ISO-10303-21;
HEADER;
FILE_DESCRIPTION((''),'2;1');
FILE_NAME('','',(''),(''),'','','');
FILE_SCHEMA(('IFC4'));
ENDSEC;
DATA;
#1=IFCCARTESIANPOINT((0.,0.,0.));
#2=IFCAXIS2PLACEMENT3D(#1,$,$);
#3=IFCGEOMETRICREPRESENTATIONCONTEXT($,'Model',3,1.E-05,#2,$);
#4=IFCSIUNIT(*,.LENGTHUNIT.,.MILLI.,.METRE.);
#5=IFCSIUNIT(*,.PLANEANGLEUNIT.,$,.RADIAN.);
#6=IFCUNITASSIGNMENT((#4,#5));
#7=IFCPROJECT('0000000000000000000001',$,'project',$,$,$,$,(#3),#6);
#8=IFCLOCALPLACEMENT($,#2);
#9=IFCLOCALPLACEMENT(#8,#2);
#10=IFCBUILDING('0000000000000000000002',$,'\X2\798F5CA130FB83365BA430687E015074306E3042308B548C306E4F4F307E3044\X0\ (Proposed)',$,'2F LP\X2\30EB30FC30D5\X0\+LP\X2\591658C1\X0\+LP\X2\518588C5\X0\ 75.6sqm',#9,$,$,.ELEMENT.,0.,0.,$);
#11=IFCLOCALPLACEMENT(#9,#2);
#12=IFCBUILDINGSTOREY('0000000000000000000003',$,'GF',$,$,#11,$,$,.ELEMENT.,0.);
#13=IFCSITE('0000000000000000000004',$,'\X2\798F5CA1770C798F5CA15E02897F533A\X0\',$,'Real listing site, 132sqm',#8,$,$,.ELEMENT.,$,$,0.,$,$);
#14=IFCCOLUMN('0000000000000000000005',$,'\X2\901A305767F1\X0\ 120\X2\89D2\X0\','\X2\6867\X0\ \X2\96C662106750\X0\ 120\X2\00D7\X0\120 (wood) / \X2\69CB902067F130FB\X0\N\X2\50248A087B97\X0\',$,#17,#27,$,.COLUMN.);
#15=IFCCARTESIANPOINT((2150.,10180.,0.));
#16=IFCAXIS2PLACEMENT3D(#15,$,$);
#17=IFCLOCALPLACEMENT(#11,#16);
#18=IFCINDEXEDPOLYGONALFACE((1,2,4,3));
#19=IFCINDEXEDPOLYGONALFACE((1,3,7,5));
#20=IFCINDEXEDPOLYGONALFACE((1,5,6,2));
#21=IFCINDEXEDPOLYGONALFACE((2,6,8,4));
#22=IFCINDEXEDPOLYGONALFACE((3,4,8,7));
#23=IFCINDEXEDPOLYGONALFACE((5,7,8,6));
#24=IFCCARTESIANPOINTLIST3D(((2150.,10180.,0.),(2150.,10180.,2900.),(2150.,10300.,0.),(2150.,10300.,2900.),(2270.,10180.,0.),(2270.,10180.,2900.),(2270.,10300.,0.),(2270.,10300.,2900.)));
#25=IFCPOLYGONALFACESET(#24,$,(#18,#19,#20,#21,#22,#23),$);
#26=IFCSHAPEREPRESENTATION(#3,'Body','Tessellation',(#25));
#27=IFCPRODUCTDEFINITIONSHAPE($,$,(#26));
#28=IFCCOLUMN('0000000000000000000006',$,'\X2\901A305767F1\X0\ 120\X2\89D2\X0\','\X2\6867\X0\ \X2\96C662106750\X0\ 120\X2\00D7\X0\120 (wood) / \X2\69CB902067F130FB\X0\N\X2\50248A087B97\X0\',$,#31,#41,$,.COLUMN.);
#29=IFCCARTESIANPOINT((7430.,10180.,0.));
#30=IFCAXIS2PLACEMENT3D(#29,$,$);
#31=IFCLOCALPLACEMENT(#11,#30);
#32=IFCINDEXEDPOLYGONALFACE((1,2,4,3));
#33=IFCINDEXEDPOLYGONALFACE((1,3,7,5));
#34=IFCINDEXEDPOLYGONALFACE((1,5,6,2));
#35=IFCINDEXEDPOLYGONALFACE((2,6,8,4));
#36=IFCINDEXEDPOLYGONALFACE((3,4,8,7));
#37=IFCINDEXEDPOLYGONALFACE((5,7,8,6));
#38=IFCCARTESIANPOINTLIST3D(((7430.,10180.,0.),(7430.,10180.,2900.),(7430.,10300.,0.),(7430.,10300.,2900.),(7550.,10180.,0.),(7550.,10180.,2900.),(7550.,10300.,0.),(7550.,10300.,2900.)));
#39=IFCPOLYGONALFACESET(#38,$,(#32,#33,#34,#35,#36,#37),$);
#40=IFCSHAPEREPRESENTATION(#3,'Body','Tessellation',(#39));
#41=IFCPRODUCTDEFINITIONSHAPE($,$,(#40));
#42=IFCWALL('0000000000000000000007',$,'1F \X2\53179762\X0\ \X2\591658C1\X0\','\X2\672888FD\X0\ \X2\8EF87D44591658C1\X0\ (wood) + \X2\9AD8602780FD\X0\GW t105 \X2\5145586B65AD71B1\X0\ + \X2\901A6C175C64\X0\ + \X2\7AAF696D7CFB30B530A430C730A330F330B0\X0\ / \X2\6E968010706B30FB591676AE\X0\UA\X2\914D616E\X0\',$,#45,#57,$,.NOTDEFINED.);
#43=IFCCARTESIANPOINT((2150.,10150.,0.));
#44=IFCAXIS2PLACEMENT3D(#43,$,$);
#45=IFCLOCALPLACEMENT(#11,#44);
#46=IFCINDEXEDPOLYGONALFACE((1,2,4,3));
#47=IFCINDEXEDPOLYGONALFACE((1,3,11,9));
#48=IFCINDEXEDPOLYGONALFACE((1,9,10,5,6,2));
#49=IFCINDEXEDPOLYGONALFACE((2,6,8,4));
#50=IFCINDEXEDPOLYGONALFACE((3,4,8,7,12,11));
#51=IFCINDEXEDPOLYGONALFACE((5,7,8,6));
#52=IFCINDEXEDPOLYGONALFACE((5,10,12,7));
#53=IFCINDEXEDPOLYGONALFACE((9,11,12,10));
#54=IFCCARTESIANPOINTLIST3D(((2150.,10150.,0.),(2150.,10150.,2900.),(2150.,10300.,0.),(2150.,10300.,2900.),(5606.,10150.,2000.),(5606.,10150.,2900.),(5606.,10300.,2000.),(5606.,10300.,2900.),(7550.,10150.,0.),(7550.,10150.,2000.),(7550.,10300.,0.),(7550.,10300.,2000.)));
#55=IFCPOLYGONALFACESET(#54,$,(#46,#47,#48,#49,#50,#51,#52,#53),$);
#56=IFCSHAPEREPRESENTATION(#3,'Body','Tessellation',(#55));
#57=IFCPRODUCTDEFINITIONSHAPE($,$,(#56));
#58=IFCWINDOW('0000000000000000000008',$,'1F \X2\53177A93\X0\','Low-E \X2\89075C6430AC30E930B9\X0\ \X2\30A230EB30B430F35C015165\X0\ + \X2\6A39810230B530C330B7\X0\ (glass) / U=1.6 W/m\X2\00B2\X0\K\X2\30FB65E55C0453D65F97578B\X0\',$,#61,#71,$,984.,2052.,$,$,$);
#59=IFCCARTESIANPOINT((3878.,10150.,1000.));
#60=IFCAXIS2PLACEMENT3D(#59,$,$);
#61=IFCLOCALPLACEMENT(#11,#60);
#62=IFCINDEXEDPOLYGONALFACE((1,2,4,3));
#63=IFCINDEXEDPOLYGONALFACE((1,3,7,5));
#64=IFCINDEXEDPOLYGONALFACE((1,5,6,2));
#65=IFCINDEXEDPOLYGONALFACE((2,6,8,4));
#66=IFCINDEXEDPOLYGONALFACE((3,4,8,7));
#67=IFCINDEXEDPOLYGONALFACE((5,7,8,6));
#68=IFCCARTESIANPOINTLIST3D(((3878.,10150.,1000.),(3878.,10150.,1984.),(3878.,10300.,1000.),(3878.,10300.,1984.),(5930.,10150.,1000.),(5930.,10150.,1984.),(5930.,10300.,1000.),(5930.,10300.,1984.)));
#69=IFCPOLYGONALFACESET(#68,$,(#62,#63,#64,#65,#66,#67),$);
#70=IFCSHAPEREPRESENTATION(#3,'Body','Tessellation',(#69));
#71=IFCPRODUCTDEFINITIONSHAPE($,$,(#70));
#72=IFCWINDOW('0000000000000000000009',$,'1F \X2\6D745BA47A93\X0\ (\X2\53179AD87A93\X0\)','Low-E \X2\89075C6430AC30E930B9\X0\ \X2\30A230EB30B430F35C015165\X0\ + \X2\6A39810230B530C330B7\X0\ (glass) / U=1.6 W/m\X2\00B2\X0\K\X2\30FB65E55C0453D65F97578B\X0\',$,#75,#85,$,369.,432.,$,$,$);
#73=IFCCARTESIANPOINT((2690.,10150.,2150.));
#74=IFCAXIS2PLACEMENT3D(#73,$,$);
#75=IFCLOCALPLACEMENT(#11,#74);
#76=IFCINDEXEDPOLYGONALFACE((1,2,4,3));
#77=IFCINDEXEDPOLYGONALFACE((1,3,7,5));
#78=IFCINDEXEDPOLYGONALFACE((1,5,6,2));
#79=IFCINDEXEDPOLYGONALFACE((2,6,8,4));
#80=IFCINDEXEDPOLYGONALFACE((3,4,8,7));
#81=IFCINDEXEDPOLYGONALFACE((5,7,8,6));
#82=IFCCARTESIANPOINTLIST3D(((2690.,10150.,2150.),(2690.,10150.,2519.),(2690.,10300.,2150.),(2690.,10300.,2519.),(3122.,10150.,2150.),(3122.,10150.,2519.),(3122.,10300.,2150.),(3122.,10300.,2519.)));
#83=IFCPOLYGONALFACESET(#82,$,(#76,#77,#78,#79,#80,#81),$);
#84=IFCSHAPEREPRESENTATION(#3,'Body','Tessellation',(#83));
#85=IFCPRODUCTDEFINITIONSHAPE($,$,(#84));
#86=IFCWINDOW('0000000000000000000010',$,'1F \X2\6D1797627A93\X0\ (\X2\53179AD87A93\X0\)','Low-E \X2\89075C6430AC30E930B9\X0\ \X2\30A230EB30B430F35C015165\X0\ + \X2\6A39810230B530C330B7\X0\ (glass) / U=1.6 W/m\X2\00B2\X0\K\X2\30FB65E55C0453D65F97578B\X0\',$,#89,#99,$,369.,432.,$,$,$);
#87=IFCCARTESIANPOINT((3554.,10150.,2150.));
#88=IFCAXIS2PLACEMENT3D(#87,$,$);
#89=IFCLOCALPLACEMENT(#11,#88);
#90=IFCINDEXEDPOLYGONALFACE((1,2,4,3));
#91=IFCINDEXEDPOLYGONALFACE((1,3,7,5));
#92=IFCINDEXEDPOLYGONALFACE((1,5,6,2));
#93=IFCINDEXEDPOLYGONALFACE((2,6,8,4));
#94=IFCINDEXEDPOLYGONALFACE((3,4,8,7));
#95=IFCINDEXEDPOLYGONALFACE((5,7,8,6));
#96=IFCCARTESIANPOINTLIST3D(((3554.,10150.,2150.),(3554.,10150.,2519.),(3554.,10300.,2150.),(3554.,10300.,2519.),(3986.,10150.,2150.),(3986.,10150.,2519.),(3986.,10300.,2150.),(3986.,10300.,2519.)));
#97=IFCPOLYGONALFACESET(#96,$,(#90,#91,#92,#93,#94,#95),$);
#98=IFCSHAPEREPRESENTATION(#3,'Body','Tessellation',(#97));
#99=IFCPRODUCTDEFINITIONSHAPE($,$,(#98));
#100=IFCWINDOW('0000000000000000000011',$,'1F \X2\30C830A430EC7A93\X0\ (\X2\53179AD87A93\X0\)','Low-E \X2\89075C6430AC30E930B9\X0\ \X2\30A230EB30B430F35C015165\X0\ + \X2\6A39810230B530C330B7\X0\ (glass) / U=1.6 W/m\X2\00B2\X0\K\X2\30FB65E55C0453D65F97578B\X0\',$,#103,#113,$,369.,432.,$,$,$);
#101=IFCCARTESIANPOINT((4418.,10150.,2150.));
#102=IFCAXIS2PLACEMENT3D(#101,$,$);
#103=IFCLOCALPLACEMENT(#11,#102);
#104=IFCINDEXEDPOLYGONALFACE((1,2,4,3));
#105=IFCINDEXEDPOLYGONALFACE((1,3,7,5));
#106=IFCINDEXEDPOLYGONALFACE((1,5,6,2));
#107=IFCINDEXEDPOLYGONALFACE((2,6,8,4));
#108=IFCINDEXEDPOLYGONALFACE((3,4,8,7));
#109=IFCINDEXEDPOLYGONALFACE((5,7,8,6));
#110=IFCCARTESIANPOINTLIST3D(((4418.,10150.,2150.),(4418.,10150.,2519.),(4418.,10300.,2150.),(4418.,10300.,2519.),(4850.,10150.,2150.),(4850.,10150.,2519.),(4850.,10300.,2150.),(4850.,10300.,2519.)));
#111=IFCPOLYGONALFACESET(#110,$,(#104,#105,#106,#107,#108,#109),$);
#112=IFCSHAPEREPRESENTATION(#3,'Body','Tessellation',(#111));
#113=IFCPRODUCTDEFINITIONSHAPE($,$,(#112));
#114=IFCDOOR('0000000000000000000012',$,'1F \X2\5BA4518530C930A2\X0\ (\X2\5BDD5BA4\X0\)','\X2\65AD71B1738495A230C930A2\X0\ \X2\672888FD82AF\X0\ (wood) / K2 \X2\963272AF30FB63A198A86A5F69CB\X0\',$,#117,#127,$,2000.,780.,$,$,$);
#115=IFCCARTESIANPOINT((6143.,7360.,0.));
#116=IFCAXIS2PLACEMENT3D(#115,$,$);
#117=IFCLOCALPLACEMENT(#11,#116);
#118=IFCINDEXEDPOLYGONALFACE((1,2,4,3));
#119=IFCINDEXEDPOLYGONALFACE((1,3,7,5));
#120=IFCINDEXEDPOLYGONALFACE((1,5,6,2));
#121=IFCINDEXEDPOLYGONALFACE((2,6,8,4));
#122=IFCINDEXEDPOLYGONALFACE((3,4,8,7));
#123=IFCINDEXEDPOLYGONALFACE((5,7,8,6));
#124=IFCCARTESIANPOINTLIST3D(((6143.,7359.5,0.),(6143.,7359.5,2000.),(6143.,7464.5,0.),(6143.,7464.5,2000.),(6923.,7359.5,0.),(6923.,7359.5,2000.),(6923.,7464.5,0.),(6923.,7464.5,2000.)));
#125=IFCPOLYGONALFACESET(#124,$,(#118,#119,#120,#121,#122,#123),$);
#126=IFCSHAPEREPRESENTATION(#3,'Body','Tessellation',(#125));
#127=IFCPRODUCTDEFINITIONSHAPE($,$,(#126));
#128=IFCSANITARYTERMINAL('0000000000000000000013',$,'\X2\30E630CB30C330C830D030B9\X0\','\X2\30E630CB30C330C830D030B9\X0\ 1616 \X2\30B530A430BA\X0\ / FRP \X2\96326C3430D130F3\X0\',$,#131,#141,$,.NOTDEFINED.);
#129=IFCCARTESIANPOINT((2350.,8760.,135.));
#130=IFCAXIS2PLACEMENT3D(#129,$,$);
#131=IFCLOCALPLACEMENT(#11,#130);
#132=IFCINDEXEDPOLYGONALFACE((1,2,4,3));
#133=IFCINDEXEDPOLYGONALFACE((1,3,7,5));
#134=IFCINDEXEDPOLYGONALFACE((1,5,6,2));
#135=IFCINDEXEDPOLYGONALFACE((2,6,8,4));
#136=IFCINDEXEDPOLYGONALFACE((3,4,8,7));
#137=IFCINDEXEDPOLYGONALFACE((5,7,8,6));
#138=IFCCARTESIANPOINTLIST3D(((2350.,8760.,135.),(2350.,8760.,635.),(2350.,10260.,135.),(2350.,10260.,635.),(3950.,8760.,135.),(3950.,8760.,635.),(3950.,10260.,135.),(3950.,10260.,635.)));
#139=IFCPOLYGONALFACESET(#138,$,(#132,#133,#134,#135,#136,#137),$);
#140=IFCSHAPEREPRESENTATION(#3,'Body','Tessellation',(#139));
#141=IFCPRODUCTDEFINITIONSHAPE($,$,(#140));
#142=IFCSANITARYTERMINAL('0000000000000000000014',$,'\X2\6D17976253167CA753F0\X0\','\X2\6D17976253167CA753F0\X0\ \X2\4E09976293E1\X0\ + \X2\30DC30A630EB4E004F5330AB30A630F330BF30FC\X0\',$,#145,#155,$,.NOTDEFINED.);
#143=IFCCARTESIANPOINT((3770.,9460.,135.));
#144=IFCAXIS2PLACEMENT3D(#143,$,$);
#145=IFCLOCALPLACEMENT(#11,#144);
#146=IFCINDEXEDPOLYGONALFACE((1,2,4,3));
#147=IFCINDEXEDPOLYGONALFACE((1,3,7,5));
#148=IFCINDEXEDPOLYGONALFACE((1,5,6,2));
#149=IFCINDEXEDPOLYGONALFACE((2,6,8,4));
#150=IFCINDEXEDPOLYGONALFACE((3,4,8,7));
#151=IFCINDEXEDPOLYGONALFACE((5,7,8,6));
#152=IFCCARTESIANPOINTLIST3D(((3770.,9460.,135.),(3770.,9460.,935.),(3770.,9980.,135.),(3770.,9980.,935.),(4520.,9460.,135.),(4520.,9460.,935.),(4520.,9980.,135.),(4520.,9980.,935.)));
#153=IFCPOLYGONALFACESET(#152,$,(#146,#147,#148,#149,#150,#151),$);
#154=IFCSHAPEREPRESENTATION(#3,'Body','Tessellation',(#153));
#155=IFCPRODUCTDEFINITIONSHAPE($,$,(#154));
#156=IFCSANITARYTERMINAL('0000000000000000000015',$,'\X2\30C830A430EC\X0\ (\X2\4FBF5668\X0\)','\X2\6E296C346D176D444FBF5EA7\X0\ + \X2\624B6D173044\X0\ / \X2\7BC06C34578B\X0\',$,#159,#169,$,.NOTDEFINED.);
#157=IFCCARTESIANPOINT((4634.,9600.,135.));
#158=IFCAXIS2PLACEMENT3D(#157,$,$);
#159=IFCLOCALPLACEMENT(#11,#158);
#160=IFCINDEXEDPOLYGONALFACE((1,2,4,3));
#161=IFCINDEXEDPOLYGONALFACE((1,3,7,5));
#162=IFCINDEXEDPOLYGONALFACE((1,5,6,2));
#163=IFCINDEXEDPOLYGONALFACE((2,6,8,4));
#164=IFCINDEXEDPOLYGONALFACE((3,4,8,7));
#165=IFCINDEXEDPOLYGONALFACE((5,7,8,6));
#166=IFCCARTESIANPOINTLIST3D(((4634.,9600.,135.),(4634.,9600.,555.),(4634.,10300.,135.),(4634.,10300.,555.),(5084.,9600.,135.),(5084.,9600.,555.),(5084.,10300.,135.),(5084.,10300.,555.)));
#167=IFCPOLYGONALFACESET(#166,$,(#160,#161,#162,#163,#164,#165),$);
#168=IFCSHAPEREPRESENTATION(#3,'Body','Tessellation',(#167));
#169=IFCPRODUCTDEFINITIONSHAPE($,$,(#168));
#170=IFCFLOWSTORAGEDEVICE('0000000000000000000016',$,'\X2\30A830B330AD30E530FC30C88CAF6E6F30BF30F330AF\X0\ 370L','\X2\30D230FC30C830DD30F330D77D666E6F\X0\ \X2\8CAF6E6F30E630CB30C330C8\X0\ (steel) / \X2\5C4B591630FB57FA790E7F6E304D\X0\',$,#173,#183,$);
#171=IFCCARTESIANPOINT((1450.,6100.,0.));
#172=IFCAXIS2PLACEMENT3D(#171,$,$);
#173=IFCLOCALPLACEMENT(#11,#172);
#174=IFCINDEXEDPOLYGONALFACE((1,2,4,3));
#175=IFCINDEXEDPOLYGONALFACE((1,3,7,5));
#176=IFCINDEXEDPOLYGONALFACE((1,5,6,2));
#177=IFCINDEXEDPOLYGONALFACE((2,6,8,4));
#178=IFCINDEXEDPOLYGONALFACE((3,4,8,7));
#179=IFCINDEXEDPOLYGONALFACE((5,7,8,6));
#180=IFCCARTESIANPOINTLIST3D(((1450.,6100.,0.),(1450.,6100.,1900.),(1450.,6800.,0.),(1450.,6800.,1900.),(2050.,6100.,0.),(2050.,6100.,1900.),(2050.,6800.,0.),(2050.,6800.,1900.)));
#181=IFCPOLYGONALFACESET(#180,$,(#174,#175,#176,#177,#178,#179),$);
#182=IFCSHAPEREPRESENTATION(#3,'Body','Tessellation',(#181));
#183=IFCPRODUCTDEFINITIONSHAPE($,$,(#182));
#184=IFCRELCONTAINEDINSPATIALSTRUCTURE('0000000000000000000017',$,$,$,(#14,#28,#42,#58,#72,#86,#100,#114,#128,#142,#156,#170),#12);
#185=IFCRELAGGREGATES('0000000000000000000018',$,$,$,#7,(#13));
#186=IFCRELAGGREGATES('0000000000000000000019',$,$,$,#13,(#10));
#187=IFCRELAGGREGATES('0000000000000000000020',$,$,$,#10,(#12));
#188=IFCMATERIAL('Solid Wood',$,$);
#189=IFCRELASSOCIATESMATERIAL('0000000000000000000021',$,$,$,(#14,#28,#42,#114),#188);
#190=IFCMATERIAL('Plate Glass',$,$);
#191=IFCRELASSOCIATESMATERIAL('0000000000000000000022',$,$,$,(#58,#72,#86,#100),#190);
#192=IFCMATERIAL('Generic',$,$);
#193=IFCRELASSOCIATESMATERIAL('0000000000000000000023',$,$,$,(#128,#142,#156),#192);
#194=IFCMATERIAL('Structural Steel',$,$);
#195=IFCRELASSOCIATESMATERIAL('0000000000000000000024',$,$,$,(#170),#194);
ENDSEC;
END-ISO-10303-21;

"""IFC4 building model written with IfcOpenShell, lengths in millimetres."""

from ifc_helpers import new_model, si_unit, frame, frame_2d, origin, place, context, project, spatial, rectangle, extrude, material, element, fill, save


model = new_model("IFC4")

# Units and contexts
model_context = context("Model", 3, precision=1e-05, world=origin())
ifc_project = project(units=[si_unit("LENGTHUNIT", "METRE", prefix="MILLI"), si_unit("PLANEANGLEUNIT", "RADIAN")], contexts=[model_context])

# Site, building, storey
site_placement = place(None, origin())
site = spatial("IfcSite", under=ifc_project, at=site_placement, Name="福岡県福岡市西区", ObjectType="Real listing site, 132sqm", CompositionType="ELEMENT", RefElevation=0.0)
building_placement = place(site_placement, origin())
building = spatial("IfcBuilding", under=site, at=building_placement, Name="福岡・茶室と縁側のある和の住まい (Proposed)", ObjectType="2F LPルーフ+LP外壁+LP内装 75.6sqm", CompositionType="ELEMENT", ElevationOfRefHeight=0.0, ElevationOfTerrain=0.0)
storey_placement = place(building_placement, origin())
storey = spatial("IfcBuildingStorey", under=building, at=storey_placement, Name="GF", CompositionType="ELEMENT", Elevation=0.0)

# Columns
ifc_material_1 = material(Name="Solid Wood")
column_1_placement = place(storey_placement, frame((2150.0, 10180.0, 0.0)))
element("IfcColumn", 1, at=column_1_placement, inside=storey, material=ifc_material_1, Name="通し柱 120角", Description="桧 集成材 120×120 (wood) / 構造柱・N値計算", PredefinedType="COLUMN", context=model_context, shape_type="SweptSolid", body=[
    extrude(rectangle(XDim=120.0, YDim=120.0, at=frame_2d((60.0, 60.0))), frame((2150.0, 10180.0, 0.0)), (0.0, 0.0, 1.0), 2900.0),
])
column_2_placement = place(storey_placement, frame((7430.0, 10180.0, 0.0)))
element("IfcColumn", 2, at=column_2_placement, inside=storey, material=ifc_material_1, Name="通し柱 120角", Description="桧 集成材 120×120 (wood) / 構造柱・N値計算", PredefinedType="COLUMN", context=model_context, shape_type="SweptSolid", body=[
    extrude(rectangle(XDim=120.0, YDim=120.0, at=frame_2d((60.0, 60.0))), frame((7430.0, 10180.0, 0.0)), (0.0, 0.0, 1.0), 2900.0),
])

# Wall, openings, windows
wall_1_placement = place(storey_placement, frame((2150.0, 10150.0, 0.0)))
wall_1 = element("IfcWall", 3, at=wall_1_placement, inside=storey, material=ifc_material_1, Name="1F 北面 外壁", Description="木製 軸組外壁 (wood) + 高性能GW t105 充填断熱 + 通気層 + 窯業系サイディング / 準耐火・外皮UA配慮", PredefinedType="NOTDEFINED", context=model_context, shape_type="SweptSolid", body=[
    extrude(rectangle(XDim=5400.0, YDim=150.0, at=frame_2d((2700.0, 75.0))), frame((2150.0, 10150.0, 0.0)), (0.0, 0.0, 1.0), 2900.0),
])
opening_1_placement = place(storey_placement, frame((3878.0, 10150.0, 1000.0)))
opening_1 = element("IfcOpeningElement", 4, at=opening_1_placement, cuts=wall_1, PredefinedType="NOTDEFINED", context=model_context, shape_type="SweptSolid", body=[
    extrude(rectangle(XDim=2052.0, YDim=150.0, at=frame_2d((1026.0, 75.0))), frame((3878.0, 10150.0, 1000.0)), (0.0, 0.0, 1.0), 984.0),
])
opening_2_placement = place(storey_placement, frame((2690.0, 10150.0, 2150.0)))
opening_2 = element("IfcOpeningElement", 5, at=opening_2_placement, cuts=wall_1, PredefinedType="NOTDEFINED", context=model_context, shape_type="SweptSolid", body=[
    extrude(rectangle(XDim=432.0, YDim=150.0, at=frame_2d((216.0, 75.0))), frame((2690.0, 10150.0, 2150.0)), (0.0, 0.0, 1.0), 369.0),
])
opening_3_placement = place(storey_placement, frame((3554.0, 10150.0, 2150.0)))
opening_3 = element("IfcOpeningElement", 6, at=opening_3_placement, cuts=wall_1, PredefinedType="NOTDEFINED", context=model_context, shape_type="SweptSolid", body=[
    extrude(rectangle(XDim=432.0, YDim=150.0, at=frame_2d((216.0, 75.0))), frame((3554.0, 10150.0, 2150.0)), (0.0, 0.0, 1.0), 369.0),
])
opening_4_placement = place(storey_placement, frame((4418.0, 10150.0, 2150.0)))
opening_4 = element("IfcOpeningElement", 7, at=opening_4_placement, cuts=wall_1, PredefinedType="NOTDEFINED", context=model_context, shape_type="SweptSolid", body=[
    extrude(rectangle(XDim=432.0, YDim=150.0, at=frame_2d((216.0, 75.0))), frame((4418.0, 10150.0, 2150.0)), (0.0, 0.0, 1.0), 369.0),
])
ifc_material_2 = material(Name="Plate Glass")
window_1_placement = place(storey_placement, frame((3878.0, 10150.0, 1000.0)))
window_1 = element("IfcWindow", 8, at=window_1_placement, inside=storey, material=ifc_material_2, Name="1F 北窓", Description="Low-E 複層ガラス アルゴン封入 + 樹脂サッシ (glass) / U=1.6 W/m²K・日射取得型", OverallHeight=984.0, OverallWidth=2052.0, context=model_context, shape_type="SweptSolid", body=[
    extrude(rectangle(XDim=2052.0, YDim=150.0, at=frame_2d((1026.0, 75.0))), frame((3878.0, 10150.0, 1000.0)), (0.0, 0.0, 1.0), 984.0),
])
fill(opening_1, window_1)
window_2_placement = place(storey_placement, frame((2690.0, 10150.0, 2150.0)))
window_2 = element("IfcWindow", 9, at=window_2_placement, inside=storey, material=ifc_material_2, Name="1F 浴室窓 (北高窓)", Description="Low-E 複層ガラス アルゴン封入 + 樹脂サッシ (glass) / U=1.6 W/m²K・日射取得型", OverallHeight=369.0, OverallWidth=432.0, context=model_context, shape_type="SweptSolid", body=[
    extrude(rectangle(XDim=432.0, YDim=150.0, at=frame_2d((216.0, 75.0))), frame((2690.0, 10150.0, 2150.0)), (0.0, 0.0, 1.0), 369.0),
])
fill(opening_2, window_2)
window_3_placement = place(storey_placement, frame((3554.0, 10150.0, 2150.0)))
window_3 = element("IfcWindow", 10, at=window_3_placement, inside=storey, material=ifc_material_2, Name="1F 洗面窓 (北高窓)", Description="Low-E 複層ガラス アルゴン封入 + 樹脂サッシ (glass) / U=1.6 W/m²K・日射取得型", OverallHeight=369.0, OverallWidth=432.0, context=model_context, shape_type="SweptSolid", body=[
    extrude(rectangle(XDim=432.0, YDim=150.0, at=frame_2d((216.0, 75.0))), frame((3554.0, 10150.0, 2150.0)), (0.0, 0.0, 1.0), 369.0),
])
fill(opening_3, window_3)
window_4_placement = place(storey_placement, frame((4418.0, 10150.0, 2150.0)))
window_4 = element("IfcWindow", 11, at=window_4_placement, inside=storey, material=ifc_material_2, Name="1F トイレ窓 (北高窓)", Description="Low-E 複層ガラス アルゴン封入 + 樹脂サッシ (glass) / U=1.6 W/m²K・日射取得型", OverallHeight=369.0, OverallWidth=432.0, context=model_context, shape_type="SweptSolid", body=[
    extrude(rectangle(XDim=432.0, YDim=150.0, at=frame_2d((216.0, 75.0))), frame((4418.0, 10150.0, 2150.0)), (0.0, 0.0, 1.0), 369.0),
])
fill(opening_4, window_4)

# Door
door_1_placement = place(storey_placement, frame((6143.0, 7360.0, 0.0)))
element("IfcDoor", 12, at=door_1_placement, inside=storey, material=ifc_material_1, Name="1F 室内ドア (寝室)", Description="断熱玄関ドア 木製芯 (wood) / K2 防犯・採風機構", OverallHeight=2000.0, OverallWidth=780.0, context=model_context, shape_type="SweptSolid", body=[
    extrude(rectangle(XDim=780.0, YDim=105.0, at=frame_2d((390.0, 52.0))), frame((6143.0, 7360.0, 0.0)), (0.0, 0.0, 1.0), 2000.0),
])

# Sanitary terminals
ifc_material_3 = material(Name="Generic")
sanitary_terminal_1_placement = place(storey_placement, frame((2350.0, 8760.0, 135.0)))
element("IfcSanitaryTerminal", 13, at=sanitary_terminal_1_placement, inside=storey, material=ifc_material_3, Name="ユニットバス", Description="ユニットバス 1616 サイズ / FRP 防水パン", PredefinedType="NOTDEFINED", context=model_context, shape_type="SweptSolid", body=[
    extrude(rectangle(XDim=1600.0, YDim=1500.0, at=frame_2d((800.0, 750.0))), frame((2350.0, 8760.0, 135.0)), (0.0, 0.0, 1.0), 500.0),
])
sanitary_terminal_2_placement = place(storey_placement, frame((3770.0, 9460.0, 135.0)))
element("IfcSanitaryTerminal", 14, at=sanitary_terminal_2_placement, inside=storey, material=ifc_material_3, Name="洗面化粧台", Description="洗面化粧台 三面鏡 + ボウル一体カウンター", PredefinedType="NOTDEFINED", context=model_context, shape_type="SweptSolid", body=[
    extrude(rectangle(XDim=750.0, YDim=520.0, at=frame_2d((375.0, 260.0))), frame((3770.0, 9460.0, 135.0)), (0.0, 0.0, 1.0), 800.0),
])
sanitary_terminal_3_placement = place(storey_placement, frame((4634.0, 9600.0, 135.0)))
element("IfcSanitaryTerminal", 15, at=sanitary_terminal_3_placement, inside=storey, material=ifc_material_3, Name="トイレ (便器)", Description="温水洗浄便座 + 手洗い / 節水型", PredefinedType="NOTDEFINED", context=model_context, shape_type="SweptSolid", body=[
    extrude(rectangle(XDim=450.0, YDim=700.0, at=frame_2d((225.0, 350.0))), frame((4634.0, 9600.0, 135.0)), (0.0, 0.0, 1.0), 420.0),
])

# Flow storage device
ifc_material_4 = material(Name="Structural Steel")
flow_storage_device_placement = place(storey_placement, frame((1450.0, 6100.0, 0.0)))
element("IfcFlowStorageDevice", 16, at=flow_storage_device_placement, inside=storey, material=ifc_material_4, Name="エコキュート貯湯タンク 370L", Description="ヒートポンプ給湯 貯湯ユニット (steel) / 屋外・基礎置き", context=model_context, shape_type="SweptSolid", body=[
    extrude(rectangle(XDim=600.0, YDim=700.0, at=frame_2d((300.0, 350.0))), frame((1450.0, 6100.0, 0.0)), (0.0, 0.0, 1.0), 1900.0),
])

save(model, "model.ifc")
